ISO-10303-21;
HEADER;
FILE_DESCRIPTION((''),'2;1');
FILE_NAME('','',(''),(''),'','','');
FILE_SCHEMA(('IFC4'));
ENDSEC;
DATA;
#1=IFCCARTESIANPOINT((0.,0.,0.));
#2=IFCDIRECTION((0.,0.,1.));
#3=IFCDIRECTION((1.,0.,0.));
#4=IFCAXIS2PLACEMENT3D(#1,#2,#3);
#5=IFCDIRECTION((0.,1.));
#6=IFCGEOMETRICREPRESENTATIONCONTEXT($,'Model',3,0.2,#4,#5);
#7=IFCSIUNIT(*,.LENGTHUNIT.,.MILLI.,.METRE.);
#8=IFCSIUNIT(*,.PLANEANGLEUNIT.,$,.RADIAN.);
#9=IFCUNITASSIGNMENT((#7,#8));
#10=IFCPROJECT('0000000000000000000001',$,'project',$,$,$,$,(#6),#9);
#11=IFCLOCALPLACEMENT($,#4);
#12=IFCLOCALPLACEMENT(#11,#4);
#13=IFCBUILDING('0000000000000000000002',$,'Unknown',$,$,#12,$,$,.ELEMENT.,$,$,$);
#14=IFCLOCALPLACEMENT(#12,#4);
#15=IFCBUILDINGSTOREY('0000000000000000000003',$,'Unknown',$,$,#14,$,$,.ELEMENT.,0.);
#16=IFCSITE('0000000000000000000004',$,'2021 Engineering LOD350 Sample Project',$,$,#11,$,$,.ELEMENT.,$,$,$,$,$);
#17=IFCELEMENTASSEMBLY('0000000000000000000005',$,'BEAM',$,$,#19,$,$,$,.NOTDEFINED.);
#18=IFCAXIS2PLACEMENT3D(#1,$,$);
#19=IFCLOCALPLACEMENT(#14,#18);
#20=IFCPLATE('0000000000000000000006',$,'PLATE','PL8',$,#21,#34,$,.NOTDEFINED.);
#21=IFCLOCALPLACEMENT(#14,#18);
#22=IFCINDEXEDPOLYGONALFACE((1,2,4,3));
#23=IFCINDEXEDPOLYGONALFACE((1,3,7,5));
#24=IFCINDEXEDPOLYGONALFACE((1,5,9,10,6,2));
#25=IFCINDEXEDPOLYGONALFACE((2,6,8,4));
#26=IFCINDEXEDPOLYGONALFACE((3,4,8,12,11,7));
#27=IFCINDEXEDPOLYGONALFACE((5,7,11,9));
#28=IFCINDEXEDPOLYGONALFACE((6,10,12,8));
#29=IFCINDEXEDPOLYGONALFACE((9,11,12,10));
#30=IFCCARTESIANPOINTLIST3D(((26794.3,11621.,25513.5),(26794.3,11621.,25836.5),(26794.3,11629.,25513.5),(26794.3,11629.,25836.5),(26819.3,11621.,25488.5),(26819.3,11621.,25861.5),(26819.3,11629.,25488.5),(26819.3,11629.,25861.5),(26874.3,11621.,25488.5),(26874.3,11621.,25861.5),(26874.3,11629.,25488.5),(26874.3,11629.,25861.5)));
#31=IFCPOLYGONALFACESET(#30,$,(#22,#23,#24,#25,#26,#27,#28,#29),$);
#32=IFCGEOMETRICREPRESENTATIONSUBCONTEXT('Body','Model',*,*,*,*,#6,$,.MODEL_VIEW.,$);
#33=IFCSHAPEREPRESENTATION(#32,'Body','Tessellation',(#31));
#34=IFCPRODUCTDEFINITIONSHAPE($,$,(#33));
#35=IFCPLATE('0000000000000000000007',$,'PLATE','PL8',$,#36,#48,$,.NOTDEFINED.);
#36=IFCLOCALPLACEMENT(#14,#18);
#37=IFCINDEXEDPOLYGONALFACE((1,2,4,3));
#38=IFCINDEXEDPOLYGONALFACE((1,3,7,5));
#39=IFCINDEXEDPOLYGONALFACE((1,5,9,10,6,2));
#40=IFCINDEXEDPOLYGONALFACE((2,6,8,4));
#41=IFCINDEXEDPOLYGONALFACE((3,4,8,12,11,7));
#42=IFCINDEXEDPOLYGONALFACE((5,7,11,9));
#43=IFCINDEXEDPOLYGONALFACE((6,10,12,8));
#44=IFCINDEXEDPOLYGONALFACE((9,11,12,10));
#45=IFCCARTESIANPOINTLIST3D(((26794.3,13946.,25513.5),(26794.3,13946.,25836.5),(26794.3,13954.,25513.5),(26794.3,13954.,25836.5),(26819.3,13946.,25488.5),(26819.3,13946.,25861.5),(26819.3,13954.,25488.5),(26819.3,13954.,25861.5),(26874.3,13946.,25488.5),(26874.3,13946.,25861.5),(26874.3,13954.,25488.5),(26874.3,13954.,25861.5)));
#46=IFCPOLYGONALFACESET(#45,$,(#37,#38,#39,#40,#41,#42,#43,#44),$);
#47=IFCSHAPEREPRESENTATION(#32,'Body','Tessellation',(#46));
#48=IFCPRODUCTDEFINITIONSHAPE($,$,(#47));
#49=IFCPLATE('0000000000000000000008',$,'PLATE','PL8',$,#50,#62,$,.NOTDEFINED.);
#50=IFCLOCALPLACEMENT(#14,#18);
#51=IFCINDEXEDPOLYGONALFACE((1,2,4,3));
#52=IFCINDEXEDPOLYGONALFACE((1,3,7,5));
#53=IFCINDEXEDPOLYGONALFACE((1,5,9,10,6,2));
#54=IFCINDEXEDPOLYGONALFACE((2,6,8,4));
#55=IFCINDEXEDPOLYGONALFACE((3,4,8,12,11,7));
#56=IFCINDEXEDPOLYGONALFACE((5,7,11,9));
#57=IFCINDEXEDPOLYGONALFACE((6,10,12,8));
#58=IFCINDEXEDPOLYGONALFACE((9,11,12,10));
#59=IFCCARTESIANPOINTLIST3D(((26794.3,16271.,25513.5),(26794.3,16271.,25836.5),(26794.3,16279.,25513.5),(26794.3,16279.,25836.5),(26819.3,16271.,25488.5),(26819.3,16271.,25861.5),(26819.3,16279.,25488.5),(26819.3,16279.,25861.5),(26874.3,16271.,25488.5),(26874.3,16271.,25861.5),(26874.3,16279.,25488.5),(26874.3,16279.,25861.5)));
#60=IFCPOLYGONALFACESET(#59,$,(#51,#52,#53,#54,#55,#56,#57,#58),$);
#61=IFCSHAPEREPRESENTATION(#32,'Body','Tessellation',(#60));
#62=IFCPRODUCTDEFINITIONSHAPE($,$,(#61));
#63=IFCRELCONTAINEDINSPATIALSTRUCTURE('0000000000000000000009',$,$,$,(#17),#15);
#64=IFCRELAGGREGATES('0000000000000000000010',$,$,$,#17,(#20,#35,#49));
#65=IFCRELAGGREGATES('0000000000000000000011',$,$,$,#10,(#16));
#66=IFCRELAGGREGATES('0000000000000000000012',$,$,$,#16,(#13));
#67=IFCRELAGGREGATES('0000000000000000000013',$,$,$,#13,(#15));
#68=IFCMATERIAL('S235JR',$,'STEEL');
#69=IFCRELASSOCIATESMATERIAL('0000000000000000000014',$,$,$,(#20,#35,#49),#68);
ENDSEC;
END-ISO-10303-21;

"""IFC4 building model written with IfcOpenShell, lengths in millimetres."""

from ifc_helpers import new_model, si_unit, direction, frame, origin_with_axes, place, context, subcontext, project, spatial, line, indexed_curve, outline, extrude, material, element, aggregate, save


model = new_model("IFC4")

# Units and contexts
model_context = context("Model", 3, precision=0.2, world=origin_with_axes(), true_north=direction((0.0, 1.0)))
body_context = subcontext(model_context, "Body", "Model", "MODEL_VIEW")
ifc_project = project(units=[si_unit("LENGTHUNIT", "METRE", prefix="MILLI"), si_unit("PLANEANGLEUNIT", "RADIAN")], contexts=[model_context])

# Site, building, storey
site_placement = place(None, origin_with_axes())
site = spatial("IfcSite", under=ifc_project, at=site_placement, Name="2021 Engineering LOD350 Sample Project", CompositionType="ELEMENT")
building_placement = place(site_placement, origin_with_axes())
building = spatial("IfcBuilding", under=site, at=building_placement, Name="Unknown", CompositionType="ELEMENT")
storey_placement = place(building_placement, origin_with_axes())
storey = spatial("IfcBuildingStorey", under=building, at=storey_placement, Name="Unknown", CompositionType="ELEMENT", Elevation=0.0)

# Shared definitions
ifc_material_1 = material(Name="S235JR", Category="STEEL")

# Element assembly, plates
assembly_1_placement = place(storey_placement, frame((26790.0, 23545.0, 25675.0), z_axis=(-1.0, 0.0, 0.0), x_axis=(0.0, -1.0, 0.0)))
assembly_1 = element("IfcElementAssembly", 1, at=assembly_1_placement, inside=storey, Name="BEAM", PredefinedType="NOTDEFINED")
plate_1_placement = place(assembly_1_placement, frame((11920.0, -186.5, -4.3), z_axis=(1.0, 0.0, 0.0), x_axis=(0.0, 0.0, -1.0)))
plate_1 = element("IfcPlate", 2, at=plate_1_placement, material=ifc_material_1, Name="PLATE", Description="PL8", PredefinedType="NOTDEFINED", context=body_context, shape_type="SolidModel", body=[
    extrude(outline(indexed_curve([(0.0, 25.0), (25.0, 0.0), (80.0, 0.0), (80.0, 373.0), (25.0, 373.0), (0.0, 348.0)], segments=[line(1, 2, 3, 4, 5, 6, 1)])), frame((0.0, 0.0, 4.0), z_axis=(0.0, 0.0, 1.0), x_axis=(1.0, 0.0, 0.0)), (0.0, 0.0, -1.0), 8.0),
])
plate_2_placement = place(assembly_1_placement, frame((9595.0, -186.5, -4.3), z_axis=(1.0, 0.0, 0.0), x_axis=(0.0, 0.0, -1.0)))
plate_2 = element("IfcPlate", 3, at=plate_2_placement, material=ifc_material_1, Name="PLATE", Description="PL8", PredefinedType="NOTDEFINED", context=body_context, shape_type="SolidModel", body=[
    extrude(outline(indexed_curve([(0.0, 25.0), (25.0, 0.0), (80.0, 0.0), (80.0, 373.0), (25.0, 373.0), (0.0, 348.0)], segments=[line(1, 2, 3, 4, 5, 6, 1)])), frame((0.0, 0.0, 4.0), z_axis=(0.0, 0.0, 1.0), x_axis=(1.0, 0.0, 0.0)), (0.0, 0.0, -1.0), 8.0),
])
plate_3_placement = place(assembly_1_placement, frame((7270.0, -186.5, -4.3), z_axis=(1.0, 0.0, 0.0), x_axis=(0.0, 0.0, -1.0)))
plate_3 = element("IfcPlate", 4, at=plate_3_placement, material=ifc_material_1, Name="PLATE", Description="PL8", PredefinedType="NOTDEFINED", context=body_context, shape_type="SolidModel", body=[
    extrude(outline(indexed_curve([(0.0, 25.0), (25.0, 0.0), (80.0, 0.0), (80.0, 373.0), (25.0, 373.0), (0.0, 348.0)], segments=[line(1, 2, 3, 4, 5, 6, 1)])), frame((0.0, 0.0, 4.0), z_axis=(0.0, 0.0, 1.0), x_axis=(1.0, 0.0, 0.0)), (0.0, 0.0, -1.0), 8.0),
])
aggregate(assembly_1, [plate_1, plate_2, plate_3])

save(model, "model.ifc")
